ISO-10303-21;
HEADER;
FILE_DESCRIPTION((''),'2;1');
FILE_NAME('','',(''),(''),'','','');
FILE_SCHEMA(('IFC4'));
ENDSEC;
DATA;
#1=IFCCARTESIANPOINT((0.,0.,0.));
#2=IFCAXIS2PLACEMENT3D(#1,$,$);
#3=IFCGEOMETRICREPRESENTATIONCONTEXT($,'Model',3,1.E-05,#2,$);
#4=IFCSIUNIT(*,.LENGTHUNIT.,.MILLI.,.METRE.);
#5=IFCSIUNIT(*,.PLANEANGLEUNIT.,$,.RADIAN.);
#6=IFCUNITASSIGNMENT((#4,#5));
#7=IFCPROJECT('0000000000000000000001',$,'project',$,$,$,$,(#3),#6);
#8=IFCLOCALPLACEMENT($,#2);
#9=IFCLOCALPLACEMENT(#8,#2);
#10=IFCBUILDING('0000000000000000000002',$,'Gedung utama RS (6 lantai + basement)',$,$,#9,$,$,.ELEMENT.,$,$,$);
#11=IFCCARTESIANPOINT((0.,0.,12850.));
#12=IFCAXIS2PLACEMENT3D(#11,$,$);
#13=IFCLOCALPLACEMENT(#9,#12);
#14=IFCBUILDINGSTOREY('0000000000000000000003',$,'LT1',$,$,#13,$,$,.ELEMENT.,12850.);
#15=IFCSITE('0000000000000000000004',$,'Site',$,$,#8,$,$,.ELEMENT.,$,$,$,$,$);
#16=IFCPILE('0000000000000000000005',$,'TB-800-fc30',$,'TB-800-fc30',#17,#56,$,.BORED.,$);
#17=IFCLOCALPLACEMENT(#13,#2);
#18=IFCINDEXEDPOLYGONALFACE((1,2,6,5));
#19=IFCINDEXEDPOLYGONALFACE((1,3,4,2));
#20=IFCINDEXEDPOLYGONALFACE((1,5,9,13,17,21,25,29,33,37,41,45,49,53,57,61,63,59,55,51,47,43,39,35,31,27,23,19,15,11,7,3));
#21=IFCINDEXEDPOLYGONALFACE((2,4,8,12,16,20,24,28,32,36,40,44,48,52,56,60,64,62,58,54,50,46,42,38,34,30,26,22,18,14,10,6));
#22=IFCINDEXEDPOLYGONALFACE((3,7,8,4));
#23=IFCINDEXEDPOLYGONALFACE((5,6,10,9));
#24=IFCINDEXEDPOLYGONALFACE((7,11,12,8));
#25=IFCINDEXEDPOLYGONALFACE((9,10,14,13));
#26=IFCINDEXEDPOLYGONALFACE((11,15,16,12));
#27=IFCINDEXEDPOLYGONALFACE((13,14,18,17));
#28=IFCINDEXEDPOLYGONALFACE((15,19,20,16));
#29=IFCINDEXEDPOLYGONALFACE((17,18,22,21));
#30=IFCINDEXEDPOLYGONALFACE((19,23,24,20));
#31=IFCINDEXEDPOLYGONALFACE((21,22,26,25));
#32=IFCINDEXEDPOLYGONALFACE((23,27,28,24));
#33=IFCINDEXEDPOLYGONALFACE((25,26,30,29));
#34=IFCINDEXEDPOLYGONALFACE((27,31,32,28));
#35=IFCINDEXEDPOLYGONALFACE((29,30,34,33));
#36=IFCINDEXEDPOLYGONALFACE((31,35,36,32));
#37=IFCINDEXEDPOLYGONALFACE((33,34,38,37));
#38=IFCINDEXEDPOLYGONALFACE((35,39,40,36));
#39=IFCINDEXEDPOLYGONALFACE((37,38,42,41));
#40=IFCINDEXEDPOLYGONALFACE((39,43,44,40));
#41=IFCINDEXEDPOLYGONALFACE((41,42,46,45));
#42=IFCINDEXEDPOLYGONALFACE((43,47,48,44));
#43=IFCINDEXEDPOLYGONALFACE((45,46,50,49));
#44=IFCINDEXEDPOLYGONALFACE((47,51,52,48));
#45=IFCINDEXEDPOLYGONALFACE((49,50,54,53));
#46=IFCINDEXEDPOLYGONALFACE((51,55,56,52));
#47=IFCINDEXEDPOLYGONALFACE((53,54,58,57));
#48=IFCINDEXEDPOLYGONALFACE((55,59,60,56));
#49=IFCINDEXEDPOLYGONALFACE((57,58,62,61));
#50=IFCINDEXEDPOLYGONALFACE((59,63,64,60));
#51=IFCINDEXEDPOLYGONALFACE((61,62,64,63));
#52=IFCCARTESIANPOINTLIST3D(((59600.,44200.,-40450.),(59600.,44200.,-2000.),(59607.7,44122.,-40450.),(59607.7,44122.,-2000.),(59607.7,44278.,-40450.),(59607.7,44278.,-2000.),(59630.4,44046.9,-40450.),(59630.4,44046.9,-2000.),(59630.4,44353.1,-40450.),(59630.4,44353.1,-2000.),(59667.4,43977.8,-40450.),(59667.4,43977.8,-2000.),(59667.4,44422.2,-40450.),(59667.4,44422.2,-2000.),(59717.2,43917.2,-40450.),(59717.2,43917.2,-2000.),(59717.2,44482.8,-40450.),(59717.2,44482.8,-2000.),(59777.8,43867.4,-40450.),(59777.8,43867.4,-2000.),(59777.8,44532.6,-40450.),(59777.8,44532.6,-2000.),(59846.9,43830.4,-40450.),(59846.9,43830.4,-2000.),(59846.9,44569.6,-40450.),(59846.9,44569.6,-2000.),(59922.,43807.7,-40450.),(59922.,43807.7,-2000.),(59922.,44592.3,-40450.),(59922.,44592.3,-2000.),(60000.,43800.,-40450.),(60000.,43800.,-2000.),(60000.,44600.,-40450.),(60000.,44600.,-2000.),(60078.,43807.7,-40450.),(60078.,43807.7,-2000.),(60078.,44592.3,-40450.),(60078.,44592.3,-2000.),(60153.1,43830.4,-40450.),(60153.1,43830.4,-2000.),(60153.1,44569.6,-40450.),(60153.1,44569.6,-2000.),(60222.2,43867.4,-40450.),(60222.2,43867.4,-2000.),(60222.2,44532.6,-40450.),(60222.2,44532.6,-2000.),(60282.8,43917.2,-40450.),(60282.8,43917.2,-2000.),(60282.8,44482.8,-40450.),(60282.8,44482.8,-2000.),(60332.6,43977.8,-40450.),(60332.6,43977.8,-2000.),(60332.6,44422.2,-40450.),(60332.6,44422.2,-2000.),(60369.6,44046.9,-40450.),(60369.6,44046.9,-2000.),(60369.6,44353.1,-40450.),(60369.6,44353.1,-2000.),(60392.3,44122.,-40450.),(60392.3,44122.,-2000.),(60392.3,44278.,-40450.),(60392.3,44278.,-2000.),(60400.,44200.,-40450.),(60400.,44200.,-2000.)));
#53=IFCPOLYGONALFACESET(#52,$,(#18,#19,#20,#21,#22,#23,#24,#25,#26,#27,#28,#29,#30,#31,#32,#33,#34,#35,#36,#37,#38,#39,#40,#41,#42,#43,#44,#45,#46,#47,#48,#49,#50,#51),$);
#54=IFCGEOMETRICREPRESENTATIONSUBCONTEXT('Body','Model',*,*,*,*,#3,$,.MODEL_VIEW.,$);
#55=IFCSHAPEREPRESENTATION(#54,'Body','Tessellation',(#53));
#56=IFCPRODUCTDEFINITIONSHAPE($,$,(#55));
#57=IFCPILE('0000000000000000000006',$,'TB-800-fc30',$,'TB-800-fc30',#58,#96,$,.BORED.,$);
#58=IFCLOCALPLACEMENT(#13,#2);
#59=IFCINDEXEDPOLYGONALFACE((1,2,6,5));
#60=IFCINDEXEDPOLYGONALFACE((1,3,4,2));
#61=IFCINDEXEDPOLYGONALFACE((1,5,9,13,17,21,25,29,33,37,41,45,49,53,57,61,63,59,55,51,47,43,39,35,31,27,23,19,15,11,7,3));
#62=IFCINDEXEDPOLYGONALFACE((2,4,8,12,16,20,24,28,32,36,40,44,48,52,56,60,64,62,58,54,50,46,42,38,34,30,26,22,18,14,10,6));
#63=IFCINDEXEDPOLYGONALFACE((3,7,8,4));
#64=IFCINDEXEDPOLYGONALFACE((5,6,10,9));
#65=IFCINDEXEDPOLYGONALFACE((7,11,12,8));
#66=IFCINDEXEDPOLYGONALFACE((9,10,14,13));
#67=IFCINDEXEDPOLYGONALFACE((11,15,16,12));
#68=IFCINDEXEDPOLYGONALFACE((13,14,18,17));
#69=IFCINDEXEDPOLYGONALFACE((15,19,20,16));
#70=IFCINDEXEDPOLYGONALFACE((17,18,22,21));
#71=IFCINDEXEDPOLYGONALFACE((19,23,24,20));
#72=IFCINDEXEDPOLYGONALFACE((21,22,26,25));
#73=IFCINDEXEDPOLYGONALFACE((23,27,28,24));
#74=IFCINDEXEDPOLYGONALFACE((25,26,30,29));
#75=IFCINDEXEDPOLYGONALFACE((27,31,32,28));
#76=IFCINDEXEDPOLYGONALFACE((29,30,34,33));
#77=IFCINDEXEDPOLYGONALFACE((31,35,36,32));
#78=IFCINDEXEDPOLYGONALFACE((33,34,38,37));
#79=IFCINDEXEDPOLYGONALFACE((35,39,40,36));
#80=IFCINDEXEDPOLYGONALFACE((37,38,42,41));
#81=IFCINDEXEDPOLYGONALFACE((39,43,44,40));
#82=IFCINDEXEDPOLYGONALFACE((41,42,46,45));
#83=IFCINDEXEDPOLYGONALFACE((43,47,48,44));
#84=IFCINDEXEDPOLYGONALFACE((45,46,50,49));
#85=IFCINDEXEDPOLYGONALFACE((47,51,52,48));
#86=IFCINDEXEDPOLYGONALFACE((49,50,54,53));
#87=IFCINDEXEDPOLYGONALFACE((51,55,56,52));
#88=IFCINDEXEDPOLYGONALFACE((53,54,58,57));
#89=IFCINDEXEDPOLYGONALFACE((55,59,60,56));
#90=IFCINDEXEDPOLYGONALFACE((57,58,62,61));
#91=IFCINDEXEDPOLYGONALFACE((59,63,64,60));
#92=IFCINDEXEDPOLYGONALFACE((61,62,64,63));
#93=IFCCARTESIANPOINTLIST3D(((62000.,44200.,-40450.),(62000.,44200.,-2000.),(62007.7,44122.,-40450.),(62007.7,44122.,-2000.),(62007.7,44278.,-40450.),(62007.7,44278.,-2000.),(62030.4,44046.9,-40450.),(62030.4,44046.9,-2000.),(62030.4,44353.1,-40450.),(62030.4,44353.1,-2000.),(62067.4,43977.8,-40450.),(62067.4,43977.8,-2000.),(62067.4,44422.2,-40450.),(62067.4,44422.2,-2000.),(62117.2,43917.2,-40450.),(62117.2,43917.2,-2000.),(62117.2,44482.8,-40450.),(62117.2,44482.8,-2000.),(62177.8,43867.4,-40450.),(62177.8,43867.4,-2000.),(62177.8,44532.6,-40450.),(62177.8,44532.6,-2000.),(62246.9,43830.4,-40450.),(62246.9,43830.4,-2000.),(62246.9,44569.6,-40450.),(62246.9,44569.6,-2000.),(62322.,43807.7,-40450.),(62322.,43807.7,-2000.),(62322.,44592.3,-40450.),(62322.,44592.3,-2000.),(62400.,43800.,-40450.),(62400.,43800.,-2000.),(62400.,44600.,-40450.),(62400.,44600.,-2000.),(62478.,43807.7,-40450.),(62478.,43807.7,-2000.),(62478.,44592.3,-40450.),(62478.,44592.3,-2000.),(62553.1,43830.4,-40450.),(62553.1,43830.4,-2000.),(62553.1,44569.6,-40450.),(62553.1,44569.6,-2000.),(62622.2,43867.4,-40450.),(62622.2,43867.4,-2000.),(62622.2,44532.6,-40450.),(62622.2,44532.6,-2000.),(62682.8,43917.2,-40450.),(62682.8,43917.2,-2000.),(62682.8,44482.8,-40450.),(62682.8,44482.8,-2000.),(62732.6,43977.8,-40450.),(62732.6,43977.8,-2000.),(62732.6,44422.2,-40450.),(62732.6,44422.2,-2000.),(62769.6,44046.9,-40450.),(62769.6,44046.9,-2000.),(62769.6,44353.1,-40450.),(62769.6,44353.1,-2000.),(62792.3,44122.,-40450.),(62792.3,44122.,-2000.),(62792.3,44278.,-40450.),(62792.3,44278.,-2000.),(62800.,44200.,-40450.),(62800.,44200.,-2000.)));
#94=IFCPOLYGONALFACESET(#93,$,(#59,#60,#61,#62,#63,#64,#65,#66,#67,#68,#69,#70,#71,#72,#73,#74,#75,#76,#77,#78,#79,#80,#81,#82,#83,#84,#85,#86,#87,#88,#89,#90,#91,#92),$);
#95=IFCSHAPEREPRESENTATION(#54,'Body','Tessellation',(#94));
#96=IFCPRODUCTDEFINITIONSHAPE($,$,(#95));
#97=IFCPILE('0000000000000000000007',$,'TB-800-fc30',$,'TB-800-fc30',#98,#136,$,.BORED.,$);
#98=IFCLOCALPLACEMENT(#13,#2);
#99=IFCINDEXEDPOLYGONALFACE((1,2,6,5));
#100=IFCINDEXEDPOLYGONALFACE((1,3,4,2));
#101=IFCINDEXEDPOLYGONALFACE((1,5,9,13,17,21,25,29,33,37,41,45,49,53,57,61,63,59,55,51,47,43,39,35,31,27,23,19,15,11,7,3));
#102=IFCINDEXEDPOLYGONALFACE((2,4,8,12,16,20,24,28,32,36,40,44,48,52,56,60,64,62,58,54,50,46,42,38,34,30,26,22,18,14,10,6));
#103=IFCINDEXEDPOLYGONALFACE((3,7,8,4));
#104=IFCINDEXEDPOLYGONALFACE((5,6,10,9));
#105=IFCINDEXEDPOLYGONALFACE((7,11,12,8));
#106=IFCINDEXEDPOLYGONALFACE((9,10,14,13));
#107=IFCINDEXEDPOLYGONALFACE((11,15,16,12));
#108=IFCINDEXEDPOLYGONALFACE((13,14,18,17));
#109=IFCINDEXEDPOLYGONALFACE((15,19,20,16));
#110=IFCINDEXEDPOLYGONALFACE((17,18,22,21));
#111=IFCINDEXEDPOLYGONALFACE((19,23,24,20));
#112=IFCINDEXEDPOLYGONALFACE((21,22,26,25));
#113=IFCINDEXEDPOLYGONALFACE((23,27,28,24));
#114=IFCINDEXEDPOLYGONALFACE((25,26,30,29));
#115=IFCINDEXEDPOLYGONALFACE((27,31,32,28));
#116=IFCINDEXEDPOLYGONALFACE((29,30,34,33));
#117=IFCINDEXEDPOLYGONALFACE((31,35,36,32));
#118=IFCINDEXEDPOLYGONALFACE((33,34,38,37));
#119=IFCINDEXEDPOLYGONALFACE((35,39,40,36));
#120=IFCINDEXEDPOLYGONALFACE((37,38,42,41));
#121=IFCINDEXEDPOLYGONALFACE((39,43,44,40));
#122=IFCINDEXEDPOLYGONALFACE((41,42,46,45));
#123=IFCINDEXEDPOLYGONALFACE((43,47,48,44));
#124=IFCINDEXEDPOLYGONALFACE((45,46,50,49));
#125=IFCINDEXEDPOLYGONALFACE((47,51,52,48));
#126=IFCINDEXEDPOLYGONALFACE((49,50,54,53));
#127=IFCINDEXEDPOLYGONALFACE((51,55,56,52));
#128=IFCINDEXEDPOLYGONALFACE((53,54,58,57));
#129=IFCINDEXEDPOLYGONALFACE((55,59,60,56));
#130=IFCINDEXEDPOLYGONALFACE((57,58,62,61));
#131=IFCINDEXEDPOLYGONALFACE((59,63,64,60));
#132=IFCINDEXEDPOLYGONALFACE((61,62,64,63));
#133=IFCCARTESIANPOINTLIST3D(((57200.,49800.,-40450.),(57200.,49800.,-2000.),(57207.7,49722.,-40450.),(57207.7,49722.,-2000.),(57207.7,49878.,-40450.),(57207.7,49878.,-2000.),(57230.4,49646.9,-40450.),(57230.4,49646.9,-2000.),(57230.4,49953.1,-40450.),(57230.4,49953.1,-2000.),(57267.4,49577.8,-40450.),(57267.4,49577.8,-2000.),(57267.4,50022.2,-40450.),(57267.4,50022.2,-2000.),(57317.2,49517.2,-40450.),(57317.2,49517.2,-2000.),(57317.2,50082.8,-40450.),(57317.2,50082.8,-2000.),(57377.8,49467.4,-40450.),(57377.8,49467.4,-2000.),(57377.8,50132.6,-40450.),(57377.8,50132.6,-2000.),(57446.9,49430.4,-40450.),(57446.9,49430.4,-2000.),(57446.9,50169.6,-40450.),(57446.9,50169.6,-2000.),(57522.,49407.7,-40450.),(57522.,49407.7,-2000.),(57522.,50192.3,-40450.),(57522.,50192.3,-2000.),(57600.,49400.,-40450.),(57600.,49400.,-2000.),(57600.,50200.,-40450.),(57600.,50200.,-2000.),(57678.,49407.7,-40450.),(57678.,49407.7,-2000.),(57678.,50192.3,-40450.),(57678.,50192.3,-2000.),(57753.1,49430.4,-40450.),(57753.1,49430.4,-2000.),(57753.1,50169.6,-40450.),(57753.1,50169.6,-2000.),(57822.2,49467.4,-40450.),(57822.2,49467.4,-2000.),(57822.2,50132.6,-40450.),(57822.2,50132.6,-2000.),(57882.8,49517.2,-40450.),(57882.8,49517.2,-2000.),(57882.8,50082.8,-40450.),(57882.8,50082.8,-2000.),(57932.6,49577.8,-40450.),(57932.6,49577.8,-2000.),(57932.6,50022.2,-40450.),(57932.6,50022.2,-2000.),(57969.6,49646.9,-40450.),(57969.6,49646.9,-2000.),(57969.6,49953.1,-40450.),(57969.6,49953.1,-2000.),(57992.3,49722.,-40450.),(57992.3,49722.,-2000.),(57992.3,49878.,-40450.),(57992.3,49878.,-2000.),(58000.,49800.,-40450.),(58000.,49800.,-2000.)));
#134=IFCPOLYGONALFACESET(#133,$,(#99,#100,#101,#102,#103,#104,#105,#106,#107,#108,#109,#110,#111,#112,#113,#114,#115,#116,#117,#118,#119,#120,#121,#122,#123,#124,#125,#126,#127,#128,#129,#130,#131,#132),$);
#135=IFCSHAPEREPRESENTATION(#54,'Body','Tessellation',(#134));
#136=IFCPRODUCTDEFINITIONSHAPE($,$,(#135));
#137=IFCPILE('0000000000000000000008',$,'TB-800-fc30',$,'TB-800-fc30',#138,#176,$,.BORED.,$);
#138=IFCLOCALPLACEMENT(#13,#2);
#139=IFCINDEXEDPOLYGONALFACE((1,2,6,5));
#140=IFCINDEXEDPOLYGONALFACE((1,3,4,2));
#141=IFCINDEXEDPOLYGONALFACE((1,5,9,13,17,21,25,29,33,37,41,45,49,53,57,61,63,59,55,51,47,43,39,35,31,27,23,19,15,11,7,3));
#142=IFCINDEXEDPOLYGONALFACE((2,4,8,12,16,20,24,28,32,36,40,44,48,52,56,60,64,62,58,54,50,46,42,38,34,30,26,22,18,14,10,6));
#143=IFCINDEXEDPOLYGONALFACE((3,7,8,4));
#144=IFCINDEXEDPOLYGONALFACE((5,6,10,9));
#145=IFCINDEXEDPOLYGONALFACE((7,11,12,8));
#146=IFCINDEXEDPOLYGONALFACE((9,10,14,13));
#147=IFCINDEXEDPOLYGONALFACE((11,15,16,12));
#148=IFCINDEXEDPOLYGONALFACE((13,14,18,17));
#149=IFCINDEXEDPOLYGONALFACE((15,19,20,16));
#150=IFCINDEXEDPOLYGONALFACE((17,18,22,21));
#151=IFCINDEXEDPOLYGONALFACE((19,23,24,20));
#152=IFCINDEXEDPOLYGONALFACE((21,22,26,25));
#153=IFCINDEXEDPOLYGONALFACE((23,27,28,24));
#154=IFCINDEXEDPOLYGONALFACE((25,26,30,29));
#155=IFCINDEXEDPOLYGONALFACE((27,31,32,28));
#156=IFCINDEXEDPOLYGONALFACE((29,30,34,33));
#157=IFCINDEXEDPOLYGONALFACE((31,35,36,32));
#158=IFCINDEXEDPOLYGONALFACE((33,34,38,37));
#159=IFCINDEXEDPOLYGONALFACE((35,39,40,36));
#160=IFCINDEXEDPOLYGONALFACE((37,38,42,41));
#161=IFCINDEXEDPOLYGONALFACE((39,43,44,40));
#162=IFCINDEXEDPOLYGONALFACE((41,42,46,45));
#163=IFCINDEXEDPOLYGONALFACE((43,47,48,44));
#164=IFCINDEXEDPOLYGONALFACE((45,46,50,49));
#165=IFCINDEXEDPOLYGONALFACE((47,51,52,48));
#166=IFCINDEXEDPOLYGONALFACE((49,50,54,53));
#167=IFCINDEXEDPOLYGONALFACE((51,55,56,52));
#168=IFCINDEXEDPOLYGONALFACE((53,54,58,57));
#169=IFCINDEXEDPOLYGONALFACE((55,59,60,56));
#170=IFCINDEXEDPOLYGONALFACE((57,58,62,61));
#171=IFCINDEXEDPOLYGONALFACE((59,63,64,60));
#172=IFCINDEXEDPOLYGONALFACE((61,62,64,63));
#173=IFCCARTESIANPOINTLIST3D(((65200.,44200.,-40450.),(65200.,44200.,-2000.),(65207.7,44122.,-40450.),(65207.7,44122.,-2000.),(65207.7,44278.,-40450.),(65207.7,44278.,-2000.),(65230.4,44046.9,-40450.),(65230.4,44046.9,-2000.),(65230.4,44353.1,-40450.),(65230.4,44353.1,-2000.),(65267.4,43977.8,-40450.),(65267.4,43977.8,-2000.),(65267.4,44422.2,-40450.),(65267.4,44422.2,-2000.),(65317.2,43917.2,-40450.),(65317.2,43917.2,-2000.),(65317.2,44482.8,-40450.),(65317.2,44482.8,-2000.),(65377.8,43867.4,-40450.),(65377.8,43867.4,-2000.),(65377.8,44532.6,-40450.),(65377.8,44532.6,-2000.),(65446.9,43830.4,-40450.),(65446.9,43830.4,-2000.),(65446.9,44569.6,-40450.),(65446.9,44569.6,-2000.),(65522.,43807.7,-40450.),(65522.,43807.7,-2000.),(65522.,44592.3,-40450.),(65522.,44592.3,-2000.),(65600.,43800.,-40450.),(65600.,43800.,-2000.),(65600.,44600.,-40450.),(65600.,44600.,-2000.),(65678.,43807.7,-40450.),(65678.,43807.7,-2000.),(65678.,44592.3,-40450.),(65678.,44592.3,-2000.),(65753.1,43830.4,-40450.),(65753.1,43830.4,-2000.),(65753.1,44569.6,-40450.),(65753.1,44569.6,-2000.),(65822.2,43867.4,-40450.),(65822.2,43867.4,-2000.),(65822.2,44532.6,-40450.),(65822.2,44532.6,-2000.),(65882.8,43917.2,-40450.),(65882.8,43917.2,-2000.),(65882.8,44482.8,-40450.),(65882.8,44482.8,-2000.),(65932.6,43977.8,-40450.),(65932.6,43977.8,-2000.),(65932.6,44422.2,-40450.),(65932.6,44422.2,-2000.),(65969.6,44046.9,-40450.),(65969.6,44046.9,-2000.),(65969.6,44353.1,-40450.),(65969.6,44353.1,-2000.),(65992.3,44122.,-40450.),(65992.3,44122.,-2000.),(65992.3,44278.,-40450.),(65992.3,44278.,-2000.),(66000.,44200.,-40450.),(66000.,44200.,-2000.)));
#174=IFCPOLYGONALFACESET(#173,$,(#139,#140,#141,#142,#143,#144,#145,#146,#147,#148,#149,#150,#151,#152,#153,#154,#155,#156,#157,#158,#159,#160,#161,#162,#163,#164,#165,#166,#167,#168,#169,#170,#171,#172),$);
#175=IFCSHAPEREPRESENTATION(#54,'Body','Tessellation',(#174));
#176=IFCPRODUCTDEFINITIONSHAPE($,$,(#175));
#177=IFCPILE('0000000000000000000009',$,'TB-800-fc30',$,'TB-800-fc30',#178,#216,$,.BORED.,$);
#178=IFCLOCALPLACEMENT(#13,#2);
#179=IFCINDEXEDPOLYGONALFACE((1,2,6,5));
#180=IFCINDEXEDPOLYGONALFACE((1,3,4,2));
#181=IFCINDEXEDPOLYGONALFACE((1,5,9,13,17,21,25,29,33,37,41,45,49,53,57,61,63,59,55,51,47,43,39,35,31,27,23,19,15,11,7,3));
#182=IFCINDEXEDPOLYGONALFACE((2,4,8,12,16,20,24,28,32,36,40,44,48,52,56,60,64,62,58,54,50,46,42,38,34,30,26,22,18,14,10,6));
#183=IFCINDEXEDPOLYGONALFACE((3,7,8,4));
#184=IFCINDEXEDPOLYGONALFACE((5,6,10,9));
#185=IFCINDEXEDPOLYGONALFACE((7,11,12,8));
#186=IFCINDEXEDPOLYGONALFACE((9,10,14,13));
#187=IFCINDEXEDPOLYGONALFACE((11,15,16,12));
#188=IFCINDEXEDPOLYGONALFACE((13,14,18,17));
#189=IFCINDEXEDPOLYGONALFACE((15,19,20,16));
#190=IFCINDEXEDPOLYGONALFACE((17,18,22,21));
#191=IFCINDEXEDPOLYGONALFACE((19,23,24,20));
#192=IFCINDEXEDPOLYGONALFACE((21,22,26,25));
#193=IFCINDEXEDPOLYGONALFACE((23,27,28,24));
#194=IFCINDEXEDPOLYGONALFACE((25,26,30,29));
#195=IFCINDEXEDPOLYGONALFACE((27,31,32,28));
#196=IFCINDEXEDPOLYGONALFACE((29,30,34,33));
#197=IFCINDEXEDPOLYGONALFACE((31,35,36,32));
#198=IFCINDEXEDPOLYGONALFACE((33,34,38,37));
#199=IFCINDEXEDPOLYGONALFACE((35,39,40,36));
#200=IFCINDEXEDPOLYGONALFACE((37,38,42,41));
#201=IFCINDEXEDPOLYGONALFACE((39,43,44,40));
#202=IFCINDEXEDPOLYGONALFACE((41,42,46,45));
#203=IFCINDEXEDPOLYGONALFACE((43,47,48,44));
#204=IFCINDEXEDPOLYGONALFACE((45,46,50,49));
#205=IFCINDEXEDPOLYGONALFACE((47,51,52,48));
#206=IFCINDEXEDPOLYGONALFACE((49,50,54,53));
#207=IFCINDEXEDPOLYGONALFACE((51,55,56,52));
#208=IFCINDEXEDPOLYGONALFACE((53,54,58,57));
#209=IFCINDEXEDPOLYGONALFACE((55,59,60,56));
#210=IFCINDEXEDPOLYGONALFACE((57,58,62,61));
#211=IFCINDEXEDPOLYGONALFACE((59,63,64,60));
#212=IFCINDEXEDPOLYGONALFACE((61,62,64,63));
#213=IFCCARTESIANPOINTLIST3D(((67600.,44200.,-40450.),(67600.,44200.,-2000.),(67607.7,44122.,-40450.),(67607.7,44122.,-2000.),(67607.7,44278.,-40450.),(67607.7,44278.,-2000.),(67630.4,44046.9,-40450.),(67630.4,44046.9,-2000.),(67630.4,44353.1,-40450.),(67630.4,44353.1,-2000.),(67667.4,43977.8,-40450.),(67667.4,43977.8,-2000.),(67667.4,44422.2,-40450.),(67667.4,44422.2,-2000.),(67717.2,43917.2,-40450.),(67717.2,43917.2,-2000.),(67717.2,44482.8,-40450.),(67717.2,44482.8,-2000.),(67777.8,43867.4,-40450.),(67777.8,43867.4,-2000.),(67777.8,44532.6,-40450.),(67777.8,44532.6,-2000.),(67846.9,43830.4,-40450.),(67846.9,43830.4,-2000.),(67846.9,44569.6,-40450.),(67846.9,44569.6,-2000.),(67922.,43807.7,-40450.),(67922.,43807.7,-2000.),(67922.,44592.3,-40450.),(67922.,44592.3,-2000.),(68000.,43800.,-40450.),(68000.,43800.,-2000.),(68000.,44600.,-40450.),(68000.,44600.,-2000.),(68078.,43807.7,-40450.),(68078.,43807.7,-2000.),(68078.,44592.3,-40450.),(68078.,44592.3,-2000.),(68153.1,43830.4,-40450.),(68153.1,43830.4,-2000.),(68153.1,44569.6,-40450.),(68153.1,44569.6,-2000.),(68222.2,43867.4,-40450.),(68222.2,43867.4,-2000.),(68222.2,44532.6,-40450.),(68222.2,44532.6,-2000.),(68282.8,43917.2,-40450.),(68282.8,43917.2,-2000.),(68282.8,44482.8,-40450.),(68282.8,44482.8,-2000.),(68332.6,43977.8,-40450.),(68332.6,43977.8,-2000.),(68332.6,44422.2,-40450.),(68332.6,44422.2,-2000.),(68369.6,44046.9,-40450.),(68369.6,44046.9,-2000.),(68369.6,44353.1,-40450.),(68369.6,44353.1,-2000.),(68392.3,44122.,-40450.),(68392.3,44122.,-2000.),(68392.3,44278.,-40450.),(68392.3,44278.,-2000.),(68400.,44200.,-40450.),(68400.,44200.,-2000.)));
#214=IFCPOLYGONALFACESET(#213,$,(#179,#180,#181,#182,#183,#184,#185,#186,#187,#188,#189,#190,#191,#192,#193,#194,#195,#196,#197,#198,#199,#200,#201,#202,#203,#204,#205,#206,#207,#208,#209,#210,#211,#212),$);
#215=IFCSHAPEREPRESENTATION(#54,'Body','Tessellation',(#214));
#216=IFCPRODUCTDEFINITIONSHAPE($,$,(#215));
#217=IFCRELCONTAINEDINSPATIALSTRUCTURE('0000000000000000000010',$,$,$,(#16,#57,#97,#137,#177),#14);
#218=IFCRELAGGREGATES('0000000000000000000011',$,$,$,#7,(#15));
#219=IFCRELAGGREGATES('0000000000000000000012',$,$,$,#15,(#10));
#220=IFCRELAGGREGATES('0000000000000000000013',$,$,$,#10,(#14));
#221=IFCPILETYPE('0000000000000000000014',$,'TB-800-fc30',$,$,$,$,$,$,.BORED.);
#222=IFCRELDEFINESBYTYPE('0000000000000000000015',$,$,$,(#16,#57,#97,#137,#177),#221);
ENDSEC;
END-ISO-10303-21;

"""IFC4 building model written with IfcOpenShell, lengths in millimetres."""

from ifc_helpers import new_model, si_unit, frame, origin, origin_2d, place, context, subcontext, project, spatial, circle, extrude, material_profile, profile_set, profile_usage, type_object, element, save


model = new_model("IFC4")

# Units and contexts
model_context = context("Model", 3, precision=1e-05, world=origin())
body_context = subcontext(model_context, "Body", "Model", "MODEL_VIEW")
ifc_project = project(units=[si_unit("LENGTHUNIT", "METRE", prefix="MILLI"), si_unit("PLANEANGLEUNIT", "RADIAN")], contexts=[model_context])

# Site, building, storey
site_placement = place(None, origin())
site = spatial("IfcSite", under=ifc_project, at=site_placement, Name="Site", CompositionType="ELEMENT")
building_placement = place(site_placement, origin())
building = spatial("IfcBuilding", under=site, at=building_placement, Name="Gedung utama RS (6 lantai + basement)", CompositionType="ELEMENT")
storey_placement = place(building_placement, frame((0.0, 0.0, 12850.0)))
storey = spatial("IfcBuildingStorey", under=building, at=storey_placement, Name="LT1", CompositionType="ELEMENT", Elevation=12850.0)

# Piles
ifc_material_profile_1 = material_profile(None, circle(Radius=400.0, at=origin_2d()), Name="TB-800-fc30")
ifc_profile_set_1 = profile_set([ifc_material_profile_1], Name="TB-800-fc30")
ifc_profile_usage_1 = profile_usage(ifc_profile_set_1, cardinal=5)
pile_type = type_object("IfcPileType", Name="TB-800-fc30", PredefinedType="BORED", material=ifc_profile_set_1)
for number, where, z_axis, x_axis, name in (
    (1, (60000.0, 44200.0, -40450.0), (0.0, 0.0, 1.0), (1.0, 0.0, 0.0), "TB-800-fc30"),
    (2, (62400.0, 44200.0, -40450.0), (0.0, 0.0, 1.0), (1.0, 0.0, 0.0), "TB-800-fc30"),
    (3, (57600.0, 49800.0, -40450.0), (0.0, 0.0, 1.0), (1.0, 0.0, 0.0), "TB-800-fc30"),
    (4, (65600.0, 44200.0, -40450.0), (0.0, 0.0, 1.0), (1.0, 0.0, 0.0), "TB-800-fc30"),
    (5, (68000.0, 44200.0, -40450.0), (0.0, 0.0, 1.0), (1.0, 0.0, 0.0), "TB-800-fc30"),
):
    element("IfcPile", number, at=place(storey_placement, frame(where, z_axis=z_axis, x_axis=x_axis)), inside=storey, type_object=pile_type, material=ifc_profile_usage_1, Name=name, ObjectType="TB-800-fc30", PredefinedType="BORED", context=body_context, shape_type="SweptSolid", body=[
        extrude(circle(Radius=400.0, at=origin_2d()), origin(), (0.0, 0.0, 1.0), 38450.0),
    ])

save(model, "model.ifc")
